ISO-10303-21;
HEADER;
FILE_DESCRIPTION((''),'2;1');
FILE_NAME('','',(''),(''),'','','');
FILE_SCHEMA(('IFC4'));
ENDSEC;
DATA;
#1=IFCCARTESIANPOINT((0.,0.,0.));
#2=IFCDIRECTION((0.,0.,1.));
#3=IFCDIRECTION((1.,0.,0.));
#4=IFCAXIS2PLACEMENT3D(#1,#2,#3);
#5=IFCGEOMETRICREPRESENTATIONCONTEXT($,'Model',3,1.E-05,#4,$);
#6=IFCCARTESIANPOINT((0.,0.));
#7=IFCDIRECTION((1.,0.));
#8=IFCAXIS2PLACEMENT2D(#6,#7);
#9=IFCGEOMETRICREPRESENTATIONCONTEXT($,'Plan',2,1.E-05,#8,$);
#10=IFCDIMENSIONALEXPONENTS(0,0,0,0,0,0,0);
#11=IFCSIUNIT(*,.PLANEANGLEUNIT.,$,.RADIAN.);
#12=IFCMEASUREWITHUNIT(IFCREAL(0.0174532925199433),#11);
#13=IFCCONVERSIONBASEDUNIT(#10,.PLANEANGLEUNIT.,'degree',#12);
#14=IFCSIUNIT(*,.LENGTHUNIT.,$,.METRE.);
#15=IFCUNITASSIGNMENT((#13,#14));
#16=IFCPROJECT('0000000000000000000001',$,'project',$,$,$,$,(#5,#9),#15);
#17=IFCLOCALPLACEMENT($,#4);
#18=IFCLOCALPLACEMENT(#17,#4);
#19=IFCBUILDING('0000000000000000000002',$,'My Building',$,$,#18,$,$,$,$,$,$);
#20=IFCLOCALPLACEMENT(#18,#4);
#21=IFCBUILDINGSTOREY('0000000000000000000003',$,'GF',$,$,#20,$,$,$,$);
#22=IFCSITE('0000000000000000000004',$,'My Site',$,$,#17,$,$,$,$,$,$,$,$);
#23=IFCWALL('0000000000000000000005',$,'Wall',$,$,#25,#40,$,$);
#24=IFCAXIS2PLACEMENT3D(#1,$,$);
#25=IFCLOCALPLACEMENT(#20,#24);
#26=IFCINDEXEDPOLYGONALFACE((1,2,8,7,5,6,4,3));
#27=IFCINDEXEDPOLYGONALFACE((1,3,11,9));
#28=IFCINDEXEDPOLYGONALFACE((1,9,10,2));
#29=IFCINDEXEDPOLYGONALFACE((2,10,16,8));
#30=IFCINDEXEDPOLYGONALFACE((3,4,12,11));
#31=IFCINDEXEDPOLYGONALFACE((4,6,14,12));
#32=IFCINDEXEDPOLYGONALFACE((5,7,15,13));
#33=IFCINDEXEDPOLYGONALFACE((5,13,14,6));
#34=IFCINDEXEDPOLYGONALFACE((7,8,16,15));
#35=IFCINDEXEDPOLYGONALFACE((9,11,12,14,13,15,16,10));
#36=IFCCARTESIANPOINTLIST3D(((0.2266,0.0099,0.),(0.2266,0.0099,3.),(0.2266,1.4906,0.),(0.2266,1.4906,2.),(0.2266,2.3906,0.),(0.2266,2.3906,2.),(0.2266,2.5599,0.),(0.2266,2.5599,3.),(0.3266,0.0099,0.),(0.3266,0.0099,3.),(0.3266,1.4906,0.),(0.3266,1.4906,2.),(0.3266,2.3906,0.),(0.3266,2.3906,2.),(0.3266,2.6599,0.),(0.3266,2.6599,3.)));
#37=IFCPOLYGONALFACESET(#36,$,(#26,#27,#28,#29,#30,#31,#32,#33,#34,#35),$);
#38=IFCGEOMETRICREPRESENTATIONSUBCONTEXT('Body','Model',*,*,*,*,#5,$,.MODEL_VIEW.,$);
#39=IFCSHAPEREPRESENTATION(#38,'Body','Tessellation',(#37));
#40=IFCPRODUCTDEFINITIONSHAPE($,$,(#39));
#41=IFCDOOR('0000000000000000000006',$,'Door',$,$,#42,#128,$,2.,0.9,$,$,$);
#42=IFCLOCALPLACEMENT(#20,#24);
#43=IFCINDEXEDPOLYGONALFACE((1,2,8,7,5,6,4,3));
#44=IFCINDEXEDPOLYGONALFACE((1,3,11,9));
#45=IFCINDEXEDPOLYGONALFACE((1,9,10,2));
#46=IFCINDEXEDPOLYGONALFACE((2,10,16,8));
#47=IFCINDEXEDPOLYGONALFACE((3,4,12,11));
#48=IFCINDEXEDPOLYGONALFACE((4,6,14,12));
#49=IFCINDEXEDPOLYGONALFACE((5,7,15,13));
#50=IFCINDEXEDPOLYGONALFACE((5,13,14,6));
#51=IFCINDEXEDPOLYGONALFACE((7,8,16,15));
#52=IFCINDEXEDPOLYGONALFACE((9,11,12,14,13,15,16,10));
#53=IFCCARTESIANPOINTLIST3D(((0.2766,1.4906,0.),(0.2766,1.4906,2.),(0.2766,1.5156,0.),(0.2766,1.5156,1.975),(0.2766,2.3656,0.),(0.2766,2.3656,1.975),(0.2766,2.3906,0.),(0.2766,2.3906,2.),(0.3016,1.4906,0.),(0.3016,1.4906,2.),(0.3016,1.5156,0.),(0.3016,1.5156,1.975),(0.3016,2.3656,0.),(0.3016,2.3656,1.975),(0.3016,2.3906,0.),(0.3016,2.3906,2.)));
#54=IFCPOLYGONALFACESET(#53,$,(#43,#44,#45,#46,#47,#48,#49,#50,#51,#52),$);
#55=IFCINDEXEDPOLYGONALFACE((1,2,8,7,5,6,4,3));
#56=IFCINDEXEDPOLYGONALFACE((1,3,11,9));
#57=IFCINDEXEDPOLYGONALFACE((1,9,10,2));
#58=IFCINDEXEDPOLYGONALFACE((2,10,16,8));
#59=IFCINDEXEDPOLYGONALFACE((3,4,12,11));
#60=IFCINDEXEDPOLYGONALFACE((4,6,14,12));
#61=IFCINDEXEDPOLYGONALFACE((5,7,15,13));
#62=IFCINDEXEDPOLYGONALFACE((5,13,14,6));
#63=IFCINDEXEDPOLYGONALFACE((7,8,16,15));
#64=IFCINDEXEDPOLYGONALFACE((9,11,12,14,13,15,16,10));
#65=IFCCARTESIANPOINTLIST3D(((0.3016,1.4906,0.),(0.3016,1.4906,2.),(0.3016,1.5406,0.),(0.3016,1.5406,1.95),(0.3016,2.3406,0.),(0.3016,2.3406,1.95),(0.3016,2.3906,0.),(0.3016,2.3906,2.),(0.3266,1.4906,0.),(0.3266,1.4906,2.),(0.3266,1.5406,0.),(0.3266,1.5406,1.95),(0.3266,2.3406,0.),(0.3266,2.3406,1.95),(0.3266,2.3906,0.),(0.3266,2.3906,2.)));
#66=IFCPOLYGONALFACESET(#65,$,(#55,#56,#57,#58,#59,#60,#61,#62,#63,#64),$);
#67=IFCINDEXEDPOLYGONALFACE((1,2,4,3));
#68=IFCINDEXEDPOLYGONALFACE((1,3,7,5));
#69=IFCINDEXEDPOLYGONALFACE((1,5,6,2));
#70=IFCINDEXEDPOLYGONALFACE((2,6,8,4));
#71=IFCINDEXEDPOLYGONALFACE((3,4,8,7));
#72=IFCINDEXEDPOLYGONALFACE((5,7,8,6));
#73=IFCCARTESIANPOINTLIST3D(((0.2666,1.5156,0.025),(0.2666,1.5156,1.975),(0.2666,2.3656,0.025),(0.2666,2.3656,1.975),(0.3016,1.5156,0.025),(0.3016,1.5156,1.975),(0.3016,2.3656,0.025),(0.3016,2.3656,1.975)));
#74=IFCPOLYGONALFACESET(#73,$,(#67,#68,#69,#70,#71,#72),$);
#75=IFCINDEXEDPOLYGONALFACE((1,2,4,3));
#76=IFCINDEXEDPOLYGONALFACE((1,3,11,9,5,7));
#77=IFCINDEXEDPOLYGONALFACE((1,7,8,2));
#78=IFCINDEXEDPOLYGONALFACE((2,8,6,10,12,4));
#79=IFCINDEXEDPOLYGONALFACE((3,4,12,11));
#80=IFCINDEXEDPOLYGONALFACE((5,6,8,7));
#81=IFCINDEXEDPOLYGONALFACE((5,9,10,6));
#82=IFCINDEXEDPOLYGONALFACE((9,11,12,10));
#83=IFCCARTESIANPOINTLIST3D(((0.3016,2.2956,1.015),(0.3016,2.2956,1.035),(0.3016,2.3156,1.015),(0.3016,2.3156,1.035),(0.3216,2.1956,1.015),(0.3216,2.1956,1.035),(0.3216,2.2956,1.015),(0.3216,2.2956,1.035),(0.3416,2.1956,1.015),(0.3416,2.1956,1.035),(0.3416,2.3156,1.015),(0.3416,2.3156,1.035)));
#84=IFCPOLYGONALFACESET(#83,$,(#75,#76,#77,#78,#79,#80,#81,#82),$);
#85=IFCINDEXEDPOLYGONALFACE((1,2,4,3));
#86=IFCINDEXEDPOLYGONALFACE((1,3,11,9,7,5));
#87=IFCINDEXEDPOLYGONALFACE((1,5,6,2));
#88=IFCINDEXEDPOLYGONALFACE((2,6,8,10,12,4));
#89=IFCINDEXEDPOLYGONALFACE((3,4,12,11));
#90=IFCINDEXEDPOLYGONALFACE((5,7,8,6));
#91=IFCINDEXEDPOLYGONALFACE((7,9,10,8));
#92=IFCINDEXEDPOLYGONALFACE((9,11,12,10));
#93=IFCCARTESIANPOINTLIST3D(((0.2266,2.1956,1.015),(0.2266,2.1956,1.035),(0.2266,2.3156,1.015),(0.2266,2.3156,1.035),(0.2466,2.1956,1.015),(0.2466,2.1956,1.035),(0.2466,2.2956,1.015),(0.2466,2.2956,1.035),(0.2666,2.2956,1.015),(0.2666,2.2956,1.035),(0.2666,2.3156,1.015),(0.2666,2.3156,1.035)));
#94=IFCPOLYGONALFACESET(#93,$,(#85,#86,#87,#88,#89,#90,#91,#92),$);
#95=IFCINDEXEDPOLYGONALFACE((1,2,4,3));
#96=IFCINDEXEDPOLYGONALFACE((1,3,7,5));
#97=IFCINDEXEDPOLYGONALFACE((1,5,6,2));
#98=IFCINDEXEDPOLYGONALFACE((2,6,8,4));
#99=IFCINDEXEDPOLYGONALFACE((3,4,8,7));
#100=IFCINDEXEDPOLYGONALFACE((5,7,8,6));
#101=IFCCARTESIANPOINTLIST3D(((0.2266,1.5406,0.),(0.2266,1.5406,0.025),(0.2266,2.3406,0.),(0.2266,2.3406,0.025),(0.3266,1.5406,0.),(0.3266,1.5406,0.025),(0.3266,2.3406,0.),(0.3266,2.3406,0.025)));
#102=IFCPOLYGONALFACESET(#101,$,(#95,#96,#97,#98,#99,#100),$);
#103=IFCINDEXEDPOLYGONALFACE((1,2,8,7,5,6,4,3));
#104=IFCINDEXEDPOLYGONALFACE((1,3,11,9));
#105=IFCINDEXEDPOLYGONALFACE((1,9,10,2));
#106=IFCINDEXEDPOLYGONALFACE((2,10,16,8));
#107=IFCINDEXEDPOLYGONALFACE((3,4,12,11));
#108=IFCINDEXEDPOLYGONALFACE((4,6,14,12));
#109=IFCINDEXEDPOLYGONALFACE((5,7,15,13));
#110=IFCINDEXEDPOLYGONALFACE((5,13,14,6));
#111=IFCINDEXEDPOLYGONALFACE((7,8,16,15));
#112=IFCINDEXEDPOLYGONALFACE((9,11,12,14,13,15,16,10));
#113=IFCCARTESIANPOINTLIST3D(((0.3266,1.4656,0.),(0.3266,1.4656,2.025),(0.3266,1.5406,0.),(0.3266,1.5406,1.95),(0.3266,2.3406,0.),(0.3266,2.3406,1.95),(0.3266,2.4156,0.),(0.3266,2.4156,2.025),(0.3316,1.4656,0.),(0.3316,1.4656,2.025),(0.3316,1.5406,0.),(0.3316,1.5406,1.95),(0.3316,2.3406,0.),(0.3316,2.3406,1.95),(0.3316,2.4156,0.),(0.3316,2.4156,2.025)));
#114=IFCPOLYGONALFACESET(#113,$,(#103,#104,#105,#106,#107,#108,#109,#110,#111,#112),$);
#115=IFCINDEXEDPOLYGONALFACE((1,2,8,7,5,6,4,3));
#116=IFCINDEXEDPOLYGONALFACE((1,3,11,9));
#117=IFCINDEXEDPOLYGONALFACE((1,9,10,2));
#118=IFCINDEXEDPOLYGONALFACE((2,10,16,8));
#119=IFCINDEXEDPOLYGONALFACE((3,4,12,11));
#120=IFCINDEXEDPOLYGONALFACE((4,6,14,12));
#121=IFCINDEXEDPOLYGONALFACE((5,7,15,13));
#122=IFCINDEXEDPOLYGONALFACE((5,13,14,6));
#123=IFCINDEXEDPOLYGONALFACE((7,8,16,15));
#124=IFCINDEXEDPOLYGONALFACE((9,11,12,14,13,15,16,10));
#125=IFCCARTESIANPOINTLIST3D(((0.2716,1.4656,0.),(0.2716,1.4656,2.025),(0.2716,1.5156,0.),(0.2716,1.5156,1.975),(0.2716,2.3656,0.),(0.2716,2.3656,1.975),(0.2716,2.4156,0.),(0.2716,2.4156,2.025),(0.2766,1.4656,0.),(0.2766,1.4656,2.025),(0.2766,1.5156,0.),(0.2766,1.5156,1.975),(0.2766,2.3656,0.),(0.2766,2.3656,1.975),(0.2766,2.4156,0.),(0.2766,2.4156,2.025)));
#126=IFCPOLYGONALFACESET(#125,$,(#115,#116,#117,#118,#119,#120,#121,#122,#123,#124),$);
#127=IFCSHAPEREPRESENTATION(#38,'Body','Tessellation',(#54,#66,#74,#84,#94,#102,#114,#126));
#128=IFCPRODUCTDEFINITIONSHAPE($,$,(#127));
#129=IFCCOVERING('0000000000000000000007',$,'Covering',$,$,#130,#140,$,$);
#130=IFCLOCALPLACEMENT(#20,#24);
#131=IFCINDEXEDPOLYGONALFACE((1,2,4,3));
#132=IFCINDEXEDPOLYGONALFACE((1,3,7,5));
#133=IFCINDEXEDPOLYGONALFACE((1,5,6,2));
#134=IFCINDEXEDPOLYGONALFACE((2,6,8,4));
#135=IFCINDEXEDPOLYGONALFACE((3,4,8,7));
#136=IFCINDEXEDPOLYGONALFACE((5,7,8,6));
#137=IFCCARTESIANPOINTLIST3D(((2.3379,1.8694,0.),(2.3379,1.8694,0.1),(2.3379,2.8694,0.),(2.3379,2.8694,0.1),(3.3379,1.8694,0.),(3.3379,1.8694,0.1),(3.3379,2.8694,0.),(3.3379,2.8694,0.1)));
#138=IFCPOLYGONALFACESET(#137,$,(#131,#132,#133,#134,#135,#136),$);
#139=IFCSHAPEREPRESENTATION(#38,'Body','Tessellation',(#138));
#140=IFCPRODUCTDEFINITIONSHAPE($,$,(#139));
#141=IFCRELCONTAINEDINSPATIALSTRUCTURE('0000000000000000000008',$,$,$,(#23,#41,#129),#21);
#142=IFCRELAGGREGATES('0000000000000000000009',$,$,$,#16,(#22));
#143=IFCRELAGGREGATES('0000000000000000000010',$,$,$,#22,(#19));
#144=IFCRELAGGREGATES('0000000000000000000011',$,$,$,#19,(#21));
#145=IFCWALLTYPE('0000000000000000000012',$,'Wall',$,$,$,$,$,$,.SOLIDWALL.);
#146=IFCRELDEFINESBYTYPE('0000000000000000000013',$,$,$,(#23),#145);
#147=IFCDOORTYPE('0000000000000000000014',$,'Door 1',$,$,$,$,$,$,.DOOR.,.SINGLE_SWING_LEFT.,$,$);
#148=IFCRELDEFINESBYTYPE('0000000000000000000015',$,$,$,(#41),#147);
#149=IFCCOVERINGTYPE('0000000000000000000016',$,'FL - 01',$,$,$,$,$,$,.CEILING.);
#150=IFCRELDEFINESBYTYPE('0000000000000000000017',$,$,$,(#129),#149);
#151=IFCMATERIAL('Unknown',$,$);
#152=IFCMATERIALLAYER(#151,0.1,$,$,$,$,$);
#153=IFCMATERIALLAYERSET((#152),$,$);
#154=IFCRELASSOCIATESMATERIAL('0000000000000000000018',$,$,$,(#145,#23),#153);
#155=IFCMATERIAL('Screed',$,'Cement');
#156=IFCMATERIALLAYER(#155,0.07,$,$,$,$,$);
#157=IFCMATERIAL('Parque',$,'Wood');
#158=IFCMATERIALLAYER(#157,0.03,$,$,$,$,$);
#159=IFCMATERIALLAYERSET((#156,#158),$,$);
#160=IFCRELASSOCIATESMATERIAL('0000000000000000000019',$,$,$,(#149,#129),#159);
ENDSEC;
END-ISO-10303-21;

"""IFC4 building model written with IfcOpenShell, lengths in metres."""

from ifc_helpers import new_model, entity, si_unit, converted_unit, frame, origin_with_axes, origin_2d_with_axis, place, context, subcontext, project, spatial, line, indexed_curve, outline, extrude, shape, source, transform, mapped, material, layer, layer_set, layer_usage, type_object, type_shapes, element, fill, save


model = new_model("IFC4")

# Units and contexts
model_context = context("Model", 3, precision=1e-05, world=origin_with_axes())
plan_context = context("Plan", 2, precision=1e-05, world=origin_2d_with_axis())
body_context_1 = subcontext(model_context, "Body", "Model", "MODEL_VIEW")
body_context_2 = subcontext(plan_context, "Body", "Plan", "PLAN_VIEW")
ifc_project = project(units=[converted_unit("PLANEANGLEUNIT", "degree", entity("IfcReal", 0.0174532925199433), si_unit("PLANEANGLEUNIT", "RADIAN"), dimensions=[0, 0, 0, 0, 0, 0, 0]), si_unit("LENGTHUNIT", "METRE")], contexts=[model_context, plan_context])

# Site, building, storey
site_placement = place(None, origin_with_axes())
site = spatial("IfcSite", under=ifc_project, at=site_placement, Name="My Site")
building_placement = place(site_placement, origin_with_axes())
building = spatial("IfcBuilding", under=site, at=building_placement, Name="My Building")
storey_placement = place(building_placement, origin_with_axes())
storey = spatial("IfcBuildingStorey", under=building, at=storey_placement, Name="GF")

# Shared definitions
ifc_material_1 = material(Name="Unknown")

# Shared definitions
ifc_layer_1 = layer(ifc_material_1, 0.1)
ifc_layer_set_1 = layer_set([ifc_layer_1])
wall_type = type_object("IfcWallType", Name="Wall", PredefinedType="SOLIDWALL", material=ifc_layer_set_1)
shared_shape_1 = source(origin_with_axes(), body_context_1, "Body", "SweptSolid", [
    extrude(outline(indexed_curve([(0.0, 0.0), (0.9, 0.0), (0.9, 2.0), (0.0, 2.0)], segments=[line(1, 2, 3, 4, 1)])), frame((0.0, -0.6, 0.0), z_axis=(0.0, -1.0, 0.0), x_axis=(1.0, 0.0, 0.0)), (0.0, 0.0, -1.0), 1.2),
])
door_type = type_object("IfcDoorType", Name="Door 1", OperationType="SINGLE_SWING_LEFT", PredefinedType="DOOR")
shared_shape_2 = source(origin_with_axes(), body_context_1, "Body", "SweptSolid", [
    extrude(outline(indexed_curve([(0.0, 0.0), (0.0, 2.0), (0.9, 2.0), (0.9, 0.0), (0.875, 0.0), (0.875, 1.975), (0.025, 1.975), (0.025, 0.0)], segments=[line(1, 2, 3, 4, 5, 6, 7, 8, 1)])), frame((0.0, 0.025, 0.0), z_axis=(0.0, -1.0, 0.0), x_axis=(1.0, 0.0, 0.0)), (0.0, 0.0, -1.0), 0.025),
    extrude(outline(indexed_curve([(0.0, 0.0), (0.0, 2.0), (0.9, 2.0), (0.9, 0.0), (0.85, 0.0), (0.85, 1.95), (0.05, 1.95), (0.05, 0.0)], segments=[line(1, 2, 3, 4, 5, 6, 7, 8, 1)])), frame((0.0, 0.0, 0.0), z_axis=(0.0, -1.0, 0.0), x_axis=(1.0, 0.0, 0.0)), (0.0, 0.0, -1.0), 0.025),
    extrude(outline(indexed_curve([(0.0, 0.0), (0.85, 0.0), (0.85, 0.035), (0.0, 0.035)], segments=[line(1, 2, 3, 4, 1)])), frame((0.025, 0.025, 0.025), z_axis=(0.0, 0.0, 1.0), x_axis=(1.0, 0.0, 0.0)), (0.0, 0.0, 1.0), 1.95),
    extrude(outline(indexed_curve([(0.0, 0.0), (0.0, -0.04), (-0.12, -0.04), (-0.12, -0.02), (-0.02, -0.02), (-0.02, 0.0)], segments=[line(1, 2, 3, 4, 5, 6, 1)])), frame((0.825, 0.025, 1.015), z_axis=(0.0, 0.0, 1.0), x_axis=(1.0, 0.0, 0.0)), (0.0, 0.0, 1.0), 0.02),
    extrude(outline(indexed_curve([(0.0, 0.0), (0.0, 0.04), (-0.12, 0.04), (-0.12, 0.02), (-0.02, 0.02), (-0.02, 0.0)], segments=[line(1, 2, 3, 4, 5, 6, 1)])), frame((0.825, 0.06, 1.015), z_axis=(0.0, 0.0, 1.0), x_axis=(1.0, 0.0, 0.0)), (0.0, 0.0, 1.0), 0.02),
    extrude(outline(indexed_curve([(0.0, 0.0), (0.8, 0.0), (0.8, 0.1), (0.0, 0.1)], segments=[line(1, 2, 3, 4, 1)])), frame((0.05, 0.0, 0.0), z_axis=(0.0, 0.0, 1.0), x_axis=(1.0, 0.0, 0.0)), (0.0, 0.0, 1.0), 0.025),
    extrude(outline(indexed_curve([(0.0, 0.0), (0.0, 2.025), (0.95, 2.025), (0.95, 0.0), (0.875, 0.0), (0.875, 1.95), (0.075, 1.95), (0.075, 0.0)], segments=[line(1, 2, 3, 4, 5, 6, 7, 8, 1)])), frame((-0.025, -0.005, 0.0), z_axis=(0.0, -1.0, 0.0), x_axis=(1.0, 0.0, 0.0)), (0.0, 0.0, -1.0), 0.005),
    extrude(outline(indexed_curve([(0.0, 0.0), (0.0, 2.025), (0.95, 2.025), (0.95, 0.0), (0.9, 0.0), (0.9, 1.975), (0.05, 1.975), (0.05, 0.0)], segments=[line(1, 2, 3, 4, 5, 6, 7, 8, 1)])), frame((-0.025, 0.05, 0.0), z_axis=(0.0, -1.0, 0.0), x_axis=(1.0, 0.0, 0.0)), (0.0, 0.0, -1.0), 0.005),
])
shared_shape_3 = source(origin_with_axes(), body_context_2, "Body", "Curve2D", [
    entity("IfcIndexedPolyCurve", entity("IfcCartesianPointList2D", [[0.0, 0.0], [0.0, 0.05], [0.025, 0.05], [0.025, 0.025], [0.05, 0.025], [0.05, 0.0]]), [entity("IfcLineIndex", [1, 2, 3, 4, 5, 6, 1])]),
    entity("IfcIndexedPolyCurve", entity("IfcCartesianPointList2D", [[0.9, 0.0], [0.9, 0.05], [0.875, 0.05], [0.875, 0.025], [0.85, 0.025], [0.85, 0.0]]), [entity("IfcLineIndex", [1, 2, 3, 4, 5, 6, 1])]),
    entity("IfcTrimmedCurve", entity("IfcEllipse", entity("IfcAxis2Placement2D", entity("IfcCartesianPoint", [0.06, 0.05]), entity("IfcDirection", [1.0, 0.0])), 0.815, 0.85), [entity("IfcCartesianPoint", [0.875, 0.05])], [entity("IfcCartesianPoint", [0.06, 0.9])], True, "CARTESIAN"),
    entity("IfcIndexedPolyCurve", entity("IfcCartesianPointList2D", [[0.025, 0.05], [0.06, 0.05], [0.06, 0.9], [0.025, 0.9]]), [entity("IfcLineIndex", [1, 2, 3, 4, 1])]),
])
type_shapes(door_type, [shared_shape_2, shared_shape_3])

# Wall, opening, door
ifc_layer_usage_1 = layer_usage(ifc_layer_set_1, "AXIS2", "POSITIVE", 0.0)
wall_1_placement = place(storey_placement, frame((0.3266, 0.0099, 0.0), z_axis=(0.0, 0.0, 1.0), x_axis=(0.0, 1.0, 0.0)))
wall_1 = element("IfcWall", 1, at=wall_1_placement, inside=storey, type_object=wall_type, material=ifc_layer_usage_1, Name="Wall", context=body_context_1, shape_type="SweptSolid", body=[
    extrude(outline(indexed_curve([(0.0, 0.0), (0.0, 0.1), (2.55, 0.1), (2.65, 0.0)], segments=[line(1, 2, 3, 4, 1)])), origin_with_axes(), (0.0, 0.0, 1.0), 3.0),
])
opening_1_placement = place(wall_1_placement, frame((1.4807, 0.0, 0.0), z_axis=(0.0, 0.0, 1.0), x_axis=(1.0, 0.0, 0.0)))
opening_1 = element("IfcOpeningElement", 2, at=opening_1_placement, cuts=wall_1, PredefinedType="OPENING", context=body_context_1, shape_type="MappedRepresentation", body=[
    mapped(shared_shape_1, transform((0.0, 0.0, 0.0), x_axis=(1.0, 0.0, 0.0), y_axis=(0.0, 1.0, 0.0), z_axis=(0.0, 0.0, 1.0), scale=1.0)),
])
door_1_placement = place(opening_1_placement, frame((0.0, 0.0, 0.0), z_axis=(0.0, 0.0, 1.0), x_axis=(1.0, 0.0, 0.0)))
door_1 = element("IfcDoor", 3, at=door_1_placement, inside=storey, type_object=door_type, Name="Door", OverallHeight=2.0, OverallWidth=0.9, shapes=[
    shape(body_context_1, "Body", "MappedRepresentation", [mapped(shared_shape_2, transform((0.0, 0.0, 0.0), x_axis=(1.0, 0.0, 0.0), y_axis=(0.0, 1.0, 0.0), z_axis=(0.0, 0.0, 1.0), scale=1.0))]),
    shape(body_context_2, "Body", "MappedRepresentation", [mapped(shared_shape_3, transform((0.0, 0.0, 0.0), x_axis=(1.0, 0.0, 0.0), y_axis=(0.0, 1.0, 0.0), z_axis=(0.0, 0.0, 1.0), scale=1.0))]),
])
fill(opening_1, door_1)

# Covering
ifc_material_2 = material(Name="Screed", Category="Cement")
ifc_layer_2 = layer(ifc_material_2, 0.07)
ifc_material_3 = material(Name="Parque", Category="Wood")
ifc_layer_3 = layer(ifc_material_3, 0.03)
ifc_layer_set_2 = layer_set([ifc_layer_2, ifc_layer_3])
ifc_layer_usage_2 = layer_usage(ifc_layer_set_2, "AXIS3", "POSITIVE", 0.0)
covering_type = type_object("IfcCoveringType", Name="FL - 01", PredefinedType="CEILING", material=ifc_layer_set_2)
covering_placement = place(storey_placement, frame((2.3379, 1.8694, 0.0), z_axis=(0.0, 0.0, 1.0), x_axis=(1.0, 0.0, 0.0)))
element("IfcCovering", 4, at=covering_placement, inside=storey, type_object=covering_type, material=ifc_layer_usage_2, Name="Covering", context=body_context_1, shape_type="SweptSolid", body=[
    extrude(outline(indexed_curve([(0.0, 0.0), (1.0, 0.0), (1.0, 1.0), (0.0, 1.0), (0.0, 0.0)])), None, (0.0, 0.0, 1.0), 0.1),
])

save(model, "model.ifc")
